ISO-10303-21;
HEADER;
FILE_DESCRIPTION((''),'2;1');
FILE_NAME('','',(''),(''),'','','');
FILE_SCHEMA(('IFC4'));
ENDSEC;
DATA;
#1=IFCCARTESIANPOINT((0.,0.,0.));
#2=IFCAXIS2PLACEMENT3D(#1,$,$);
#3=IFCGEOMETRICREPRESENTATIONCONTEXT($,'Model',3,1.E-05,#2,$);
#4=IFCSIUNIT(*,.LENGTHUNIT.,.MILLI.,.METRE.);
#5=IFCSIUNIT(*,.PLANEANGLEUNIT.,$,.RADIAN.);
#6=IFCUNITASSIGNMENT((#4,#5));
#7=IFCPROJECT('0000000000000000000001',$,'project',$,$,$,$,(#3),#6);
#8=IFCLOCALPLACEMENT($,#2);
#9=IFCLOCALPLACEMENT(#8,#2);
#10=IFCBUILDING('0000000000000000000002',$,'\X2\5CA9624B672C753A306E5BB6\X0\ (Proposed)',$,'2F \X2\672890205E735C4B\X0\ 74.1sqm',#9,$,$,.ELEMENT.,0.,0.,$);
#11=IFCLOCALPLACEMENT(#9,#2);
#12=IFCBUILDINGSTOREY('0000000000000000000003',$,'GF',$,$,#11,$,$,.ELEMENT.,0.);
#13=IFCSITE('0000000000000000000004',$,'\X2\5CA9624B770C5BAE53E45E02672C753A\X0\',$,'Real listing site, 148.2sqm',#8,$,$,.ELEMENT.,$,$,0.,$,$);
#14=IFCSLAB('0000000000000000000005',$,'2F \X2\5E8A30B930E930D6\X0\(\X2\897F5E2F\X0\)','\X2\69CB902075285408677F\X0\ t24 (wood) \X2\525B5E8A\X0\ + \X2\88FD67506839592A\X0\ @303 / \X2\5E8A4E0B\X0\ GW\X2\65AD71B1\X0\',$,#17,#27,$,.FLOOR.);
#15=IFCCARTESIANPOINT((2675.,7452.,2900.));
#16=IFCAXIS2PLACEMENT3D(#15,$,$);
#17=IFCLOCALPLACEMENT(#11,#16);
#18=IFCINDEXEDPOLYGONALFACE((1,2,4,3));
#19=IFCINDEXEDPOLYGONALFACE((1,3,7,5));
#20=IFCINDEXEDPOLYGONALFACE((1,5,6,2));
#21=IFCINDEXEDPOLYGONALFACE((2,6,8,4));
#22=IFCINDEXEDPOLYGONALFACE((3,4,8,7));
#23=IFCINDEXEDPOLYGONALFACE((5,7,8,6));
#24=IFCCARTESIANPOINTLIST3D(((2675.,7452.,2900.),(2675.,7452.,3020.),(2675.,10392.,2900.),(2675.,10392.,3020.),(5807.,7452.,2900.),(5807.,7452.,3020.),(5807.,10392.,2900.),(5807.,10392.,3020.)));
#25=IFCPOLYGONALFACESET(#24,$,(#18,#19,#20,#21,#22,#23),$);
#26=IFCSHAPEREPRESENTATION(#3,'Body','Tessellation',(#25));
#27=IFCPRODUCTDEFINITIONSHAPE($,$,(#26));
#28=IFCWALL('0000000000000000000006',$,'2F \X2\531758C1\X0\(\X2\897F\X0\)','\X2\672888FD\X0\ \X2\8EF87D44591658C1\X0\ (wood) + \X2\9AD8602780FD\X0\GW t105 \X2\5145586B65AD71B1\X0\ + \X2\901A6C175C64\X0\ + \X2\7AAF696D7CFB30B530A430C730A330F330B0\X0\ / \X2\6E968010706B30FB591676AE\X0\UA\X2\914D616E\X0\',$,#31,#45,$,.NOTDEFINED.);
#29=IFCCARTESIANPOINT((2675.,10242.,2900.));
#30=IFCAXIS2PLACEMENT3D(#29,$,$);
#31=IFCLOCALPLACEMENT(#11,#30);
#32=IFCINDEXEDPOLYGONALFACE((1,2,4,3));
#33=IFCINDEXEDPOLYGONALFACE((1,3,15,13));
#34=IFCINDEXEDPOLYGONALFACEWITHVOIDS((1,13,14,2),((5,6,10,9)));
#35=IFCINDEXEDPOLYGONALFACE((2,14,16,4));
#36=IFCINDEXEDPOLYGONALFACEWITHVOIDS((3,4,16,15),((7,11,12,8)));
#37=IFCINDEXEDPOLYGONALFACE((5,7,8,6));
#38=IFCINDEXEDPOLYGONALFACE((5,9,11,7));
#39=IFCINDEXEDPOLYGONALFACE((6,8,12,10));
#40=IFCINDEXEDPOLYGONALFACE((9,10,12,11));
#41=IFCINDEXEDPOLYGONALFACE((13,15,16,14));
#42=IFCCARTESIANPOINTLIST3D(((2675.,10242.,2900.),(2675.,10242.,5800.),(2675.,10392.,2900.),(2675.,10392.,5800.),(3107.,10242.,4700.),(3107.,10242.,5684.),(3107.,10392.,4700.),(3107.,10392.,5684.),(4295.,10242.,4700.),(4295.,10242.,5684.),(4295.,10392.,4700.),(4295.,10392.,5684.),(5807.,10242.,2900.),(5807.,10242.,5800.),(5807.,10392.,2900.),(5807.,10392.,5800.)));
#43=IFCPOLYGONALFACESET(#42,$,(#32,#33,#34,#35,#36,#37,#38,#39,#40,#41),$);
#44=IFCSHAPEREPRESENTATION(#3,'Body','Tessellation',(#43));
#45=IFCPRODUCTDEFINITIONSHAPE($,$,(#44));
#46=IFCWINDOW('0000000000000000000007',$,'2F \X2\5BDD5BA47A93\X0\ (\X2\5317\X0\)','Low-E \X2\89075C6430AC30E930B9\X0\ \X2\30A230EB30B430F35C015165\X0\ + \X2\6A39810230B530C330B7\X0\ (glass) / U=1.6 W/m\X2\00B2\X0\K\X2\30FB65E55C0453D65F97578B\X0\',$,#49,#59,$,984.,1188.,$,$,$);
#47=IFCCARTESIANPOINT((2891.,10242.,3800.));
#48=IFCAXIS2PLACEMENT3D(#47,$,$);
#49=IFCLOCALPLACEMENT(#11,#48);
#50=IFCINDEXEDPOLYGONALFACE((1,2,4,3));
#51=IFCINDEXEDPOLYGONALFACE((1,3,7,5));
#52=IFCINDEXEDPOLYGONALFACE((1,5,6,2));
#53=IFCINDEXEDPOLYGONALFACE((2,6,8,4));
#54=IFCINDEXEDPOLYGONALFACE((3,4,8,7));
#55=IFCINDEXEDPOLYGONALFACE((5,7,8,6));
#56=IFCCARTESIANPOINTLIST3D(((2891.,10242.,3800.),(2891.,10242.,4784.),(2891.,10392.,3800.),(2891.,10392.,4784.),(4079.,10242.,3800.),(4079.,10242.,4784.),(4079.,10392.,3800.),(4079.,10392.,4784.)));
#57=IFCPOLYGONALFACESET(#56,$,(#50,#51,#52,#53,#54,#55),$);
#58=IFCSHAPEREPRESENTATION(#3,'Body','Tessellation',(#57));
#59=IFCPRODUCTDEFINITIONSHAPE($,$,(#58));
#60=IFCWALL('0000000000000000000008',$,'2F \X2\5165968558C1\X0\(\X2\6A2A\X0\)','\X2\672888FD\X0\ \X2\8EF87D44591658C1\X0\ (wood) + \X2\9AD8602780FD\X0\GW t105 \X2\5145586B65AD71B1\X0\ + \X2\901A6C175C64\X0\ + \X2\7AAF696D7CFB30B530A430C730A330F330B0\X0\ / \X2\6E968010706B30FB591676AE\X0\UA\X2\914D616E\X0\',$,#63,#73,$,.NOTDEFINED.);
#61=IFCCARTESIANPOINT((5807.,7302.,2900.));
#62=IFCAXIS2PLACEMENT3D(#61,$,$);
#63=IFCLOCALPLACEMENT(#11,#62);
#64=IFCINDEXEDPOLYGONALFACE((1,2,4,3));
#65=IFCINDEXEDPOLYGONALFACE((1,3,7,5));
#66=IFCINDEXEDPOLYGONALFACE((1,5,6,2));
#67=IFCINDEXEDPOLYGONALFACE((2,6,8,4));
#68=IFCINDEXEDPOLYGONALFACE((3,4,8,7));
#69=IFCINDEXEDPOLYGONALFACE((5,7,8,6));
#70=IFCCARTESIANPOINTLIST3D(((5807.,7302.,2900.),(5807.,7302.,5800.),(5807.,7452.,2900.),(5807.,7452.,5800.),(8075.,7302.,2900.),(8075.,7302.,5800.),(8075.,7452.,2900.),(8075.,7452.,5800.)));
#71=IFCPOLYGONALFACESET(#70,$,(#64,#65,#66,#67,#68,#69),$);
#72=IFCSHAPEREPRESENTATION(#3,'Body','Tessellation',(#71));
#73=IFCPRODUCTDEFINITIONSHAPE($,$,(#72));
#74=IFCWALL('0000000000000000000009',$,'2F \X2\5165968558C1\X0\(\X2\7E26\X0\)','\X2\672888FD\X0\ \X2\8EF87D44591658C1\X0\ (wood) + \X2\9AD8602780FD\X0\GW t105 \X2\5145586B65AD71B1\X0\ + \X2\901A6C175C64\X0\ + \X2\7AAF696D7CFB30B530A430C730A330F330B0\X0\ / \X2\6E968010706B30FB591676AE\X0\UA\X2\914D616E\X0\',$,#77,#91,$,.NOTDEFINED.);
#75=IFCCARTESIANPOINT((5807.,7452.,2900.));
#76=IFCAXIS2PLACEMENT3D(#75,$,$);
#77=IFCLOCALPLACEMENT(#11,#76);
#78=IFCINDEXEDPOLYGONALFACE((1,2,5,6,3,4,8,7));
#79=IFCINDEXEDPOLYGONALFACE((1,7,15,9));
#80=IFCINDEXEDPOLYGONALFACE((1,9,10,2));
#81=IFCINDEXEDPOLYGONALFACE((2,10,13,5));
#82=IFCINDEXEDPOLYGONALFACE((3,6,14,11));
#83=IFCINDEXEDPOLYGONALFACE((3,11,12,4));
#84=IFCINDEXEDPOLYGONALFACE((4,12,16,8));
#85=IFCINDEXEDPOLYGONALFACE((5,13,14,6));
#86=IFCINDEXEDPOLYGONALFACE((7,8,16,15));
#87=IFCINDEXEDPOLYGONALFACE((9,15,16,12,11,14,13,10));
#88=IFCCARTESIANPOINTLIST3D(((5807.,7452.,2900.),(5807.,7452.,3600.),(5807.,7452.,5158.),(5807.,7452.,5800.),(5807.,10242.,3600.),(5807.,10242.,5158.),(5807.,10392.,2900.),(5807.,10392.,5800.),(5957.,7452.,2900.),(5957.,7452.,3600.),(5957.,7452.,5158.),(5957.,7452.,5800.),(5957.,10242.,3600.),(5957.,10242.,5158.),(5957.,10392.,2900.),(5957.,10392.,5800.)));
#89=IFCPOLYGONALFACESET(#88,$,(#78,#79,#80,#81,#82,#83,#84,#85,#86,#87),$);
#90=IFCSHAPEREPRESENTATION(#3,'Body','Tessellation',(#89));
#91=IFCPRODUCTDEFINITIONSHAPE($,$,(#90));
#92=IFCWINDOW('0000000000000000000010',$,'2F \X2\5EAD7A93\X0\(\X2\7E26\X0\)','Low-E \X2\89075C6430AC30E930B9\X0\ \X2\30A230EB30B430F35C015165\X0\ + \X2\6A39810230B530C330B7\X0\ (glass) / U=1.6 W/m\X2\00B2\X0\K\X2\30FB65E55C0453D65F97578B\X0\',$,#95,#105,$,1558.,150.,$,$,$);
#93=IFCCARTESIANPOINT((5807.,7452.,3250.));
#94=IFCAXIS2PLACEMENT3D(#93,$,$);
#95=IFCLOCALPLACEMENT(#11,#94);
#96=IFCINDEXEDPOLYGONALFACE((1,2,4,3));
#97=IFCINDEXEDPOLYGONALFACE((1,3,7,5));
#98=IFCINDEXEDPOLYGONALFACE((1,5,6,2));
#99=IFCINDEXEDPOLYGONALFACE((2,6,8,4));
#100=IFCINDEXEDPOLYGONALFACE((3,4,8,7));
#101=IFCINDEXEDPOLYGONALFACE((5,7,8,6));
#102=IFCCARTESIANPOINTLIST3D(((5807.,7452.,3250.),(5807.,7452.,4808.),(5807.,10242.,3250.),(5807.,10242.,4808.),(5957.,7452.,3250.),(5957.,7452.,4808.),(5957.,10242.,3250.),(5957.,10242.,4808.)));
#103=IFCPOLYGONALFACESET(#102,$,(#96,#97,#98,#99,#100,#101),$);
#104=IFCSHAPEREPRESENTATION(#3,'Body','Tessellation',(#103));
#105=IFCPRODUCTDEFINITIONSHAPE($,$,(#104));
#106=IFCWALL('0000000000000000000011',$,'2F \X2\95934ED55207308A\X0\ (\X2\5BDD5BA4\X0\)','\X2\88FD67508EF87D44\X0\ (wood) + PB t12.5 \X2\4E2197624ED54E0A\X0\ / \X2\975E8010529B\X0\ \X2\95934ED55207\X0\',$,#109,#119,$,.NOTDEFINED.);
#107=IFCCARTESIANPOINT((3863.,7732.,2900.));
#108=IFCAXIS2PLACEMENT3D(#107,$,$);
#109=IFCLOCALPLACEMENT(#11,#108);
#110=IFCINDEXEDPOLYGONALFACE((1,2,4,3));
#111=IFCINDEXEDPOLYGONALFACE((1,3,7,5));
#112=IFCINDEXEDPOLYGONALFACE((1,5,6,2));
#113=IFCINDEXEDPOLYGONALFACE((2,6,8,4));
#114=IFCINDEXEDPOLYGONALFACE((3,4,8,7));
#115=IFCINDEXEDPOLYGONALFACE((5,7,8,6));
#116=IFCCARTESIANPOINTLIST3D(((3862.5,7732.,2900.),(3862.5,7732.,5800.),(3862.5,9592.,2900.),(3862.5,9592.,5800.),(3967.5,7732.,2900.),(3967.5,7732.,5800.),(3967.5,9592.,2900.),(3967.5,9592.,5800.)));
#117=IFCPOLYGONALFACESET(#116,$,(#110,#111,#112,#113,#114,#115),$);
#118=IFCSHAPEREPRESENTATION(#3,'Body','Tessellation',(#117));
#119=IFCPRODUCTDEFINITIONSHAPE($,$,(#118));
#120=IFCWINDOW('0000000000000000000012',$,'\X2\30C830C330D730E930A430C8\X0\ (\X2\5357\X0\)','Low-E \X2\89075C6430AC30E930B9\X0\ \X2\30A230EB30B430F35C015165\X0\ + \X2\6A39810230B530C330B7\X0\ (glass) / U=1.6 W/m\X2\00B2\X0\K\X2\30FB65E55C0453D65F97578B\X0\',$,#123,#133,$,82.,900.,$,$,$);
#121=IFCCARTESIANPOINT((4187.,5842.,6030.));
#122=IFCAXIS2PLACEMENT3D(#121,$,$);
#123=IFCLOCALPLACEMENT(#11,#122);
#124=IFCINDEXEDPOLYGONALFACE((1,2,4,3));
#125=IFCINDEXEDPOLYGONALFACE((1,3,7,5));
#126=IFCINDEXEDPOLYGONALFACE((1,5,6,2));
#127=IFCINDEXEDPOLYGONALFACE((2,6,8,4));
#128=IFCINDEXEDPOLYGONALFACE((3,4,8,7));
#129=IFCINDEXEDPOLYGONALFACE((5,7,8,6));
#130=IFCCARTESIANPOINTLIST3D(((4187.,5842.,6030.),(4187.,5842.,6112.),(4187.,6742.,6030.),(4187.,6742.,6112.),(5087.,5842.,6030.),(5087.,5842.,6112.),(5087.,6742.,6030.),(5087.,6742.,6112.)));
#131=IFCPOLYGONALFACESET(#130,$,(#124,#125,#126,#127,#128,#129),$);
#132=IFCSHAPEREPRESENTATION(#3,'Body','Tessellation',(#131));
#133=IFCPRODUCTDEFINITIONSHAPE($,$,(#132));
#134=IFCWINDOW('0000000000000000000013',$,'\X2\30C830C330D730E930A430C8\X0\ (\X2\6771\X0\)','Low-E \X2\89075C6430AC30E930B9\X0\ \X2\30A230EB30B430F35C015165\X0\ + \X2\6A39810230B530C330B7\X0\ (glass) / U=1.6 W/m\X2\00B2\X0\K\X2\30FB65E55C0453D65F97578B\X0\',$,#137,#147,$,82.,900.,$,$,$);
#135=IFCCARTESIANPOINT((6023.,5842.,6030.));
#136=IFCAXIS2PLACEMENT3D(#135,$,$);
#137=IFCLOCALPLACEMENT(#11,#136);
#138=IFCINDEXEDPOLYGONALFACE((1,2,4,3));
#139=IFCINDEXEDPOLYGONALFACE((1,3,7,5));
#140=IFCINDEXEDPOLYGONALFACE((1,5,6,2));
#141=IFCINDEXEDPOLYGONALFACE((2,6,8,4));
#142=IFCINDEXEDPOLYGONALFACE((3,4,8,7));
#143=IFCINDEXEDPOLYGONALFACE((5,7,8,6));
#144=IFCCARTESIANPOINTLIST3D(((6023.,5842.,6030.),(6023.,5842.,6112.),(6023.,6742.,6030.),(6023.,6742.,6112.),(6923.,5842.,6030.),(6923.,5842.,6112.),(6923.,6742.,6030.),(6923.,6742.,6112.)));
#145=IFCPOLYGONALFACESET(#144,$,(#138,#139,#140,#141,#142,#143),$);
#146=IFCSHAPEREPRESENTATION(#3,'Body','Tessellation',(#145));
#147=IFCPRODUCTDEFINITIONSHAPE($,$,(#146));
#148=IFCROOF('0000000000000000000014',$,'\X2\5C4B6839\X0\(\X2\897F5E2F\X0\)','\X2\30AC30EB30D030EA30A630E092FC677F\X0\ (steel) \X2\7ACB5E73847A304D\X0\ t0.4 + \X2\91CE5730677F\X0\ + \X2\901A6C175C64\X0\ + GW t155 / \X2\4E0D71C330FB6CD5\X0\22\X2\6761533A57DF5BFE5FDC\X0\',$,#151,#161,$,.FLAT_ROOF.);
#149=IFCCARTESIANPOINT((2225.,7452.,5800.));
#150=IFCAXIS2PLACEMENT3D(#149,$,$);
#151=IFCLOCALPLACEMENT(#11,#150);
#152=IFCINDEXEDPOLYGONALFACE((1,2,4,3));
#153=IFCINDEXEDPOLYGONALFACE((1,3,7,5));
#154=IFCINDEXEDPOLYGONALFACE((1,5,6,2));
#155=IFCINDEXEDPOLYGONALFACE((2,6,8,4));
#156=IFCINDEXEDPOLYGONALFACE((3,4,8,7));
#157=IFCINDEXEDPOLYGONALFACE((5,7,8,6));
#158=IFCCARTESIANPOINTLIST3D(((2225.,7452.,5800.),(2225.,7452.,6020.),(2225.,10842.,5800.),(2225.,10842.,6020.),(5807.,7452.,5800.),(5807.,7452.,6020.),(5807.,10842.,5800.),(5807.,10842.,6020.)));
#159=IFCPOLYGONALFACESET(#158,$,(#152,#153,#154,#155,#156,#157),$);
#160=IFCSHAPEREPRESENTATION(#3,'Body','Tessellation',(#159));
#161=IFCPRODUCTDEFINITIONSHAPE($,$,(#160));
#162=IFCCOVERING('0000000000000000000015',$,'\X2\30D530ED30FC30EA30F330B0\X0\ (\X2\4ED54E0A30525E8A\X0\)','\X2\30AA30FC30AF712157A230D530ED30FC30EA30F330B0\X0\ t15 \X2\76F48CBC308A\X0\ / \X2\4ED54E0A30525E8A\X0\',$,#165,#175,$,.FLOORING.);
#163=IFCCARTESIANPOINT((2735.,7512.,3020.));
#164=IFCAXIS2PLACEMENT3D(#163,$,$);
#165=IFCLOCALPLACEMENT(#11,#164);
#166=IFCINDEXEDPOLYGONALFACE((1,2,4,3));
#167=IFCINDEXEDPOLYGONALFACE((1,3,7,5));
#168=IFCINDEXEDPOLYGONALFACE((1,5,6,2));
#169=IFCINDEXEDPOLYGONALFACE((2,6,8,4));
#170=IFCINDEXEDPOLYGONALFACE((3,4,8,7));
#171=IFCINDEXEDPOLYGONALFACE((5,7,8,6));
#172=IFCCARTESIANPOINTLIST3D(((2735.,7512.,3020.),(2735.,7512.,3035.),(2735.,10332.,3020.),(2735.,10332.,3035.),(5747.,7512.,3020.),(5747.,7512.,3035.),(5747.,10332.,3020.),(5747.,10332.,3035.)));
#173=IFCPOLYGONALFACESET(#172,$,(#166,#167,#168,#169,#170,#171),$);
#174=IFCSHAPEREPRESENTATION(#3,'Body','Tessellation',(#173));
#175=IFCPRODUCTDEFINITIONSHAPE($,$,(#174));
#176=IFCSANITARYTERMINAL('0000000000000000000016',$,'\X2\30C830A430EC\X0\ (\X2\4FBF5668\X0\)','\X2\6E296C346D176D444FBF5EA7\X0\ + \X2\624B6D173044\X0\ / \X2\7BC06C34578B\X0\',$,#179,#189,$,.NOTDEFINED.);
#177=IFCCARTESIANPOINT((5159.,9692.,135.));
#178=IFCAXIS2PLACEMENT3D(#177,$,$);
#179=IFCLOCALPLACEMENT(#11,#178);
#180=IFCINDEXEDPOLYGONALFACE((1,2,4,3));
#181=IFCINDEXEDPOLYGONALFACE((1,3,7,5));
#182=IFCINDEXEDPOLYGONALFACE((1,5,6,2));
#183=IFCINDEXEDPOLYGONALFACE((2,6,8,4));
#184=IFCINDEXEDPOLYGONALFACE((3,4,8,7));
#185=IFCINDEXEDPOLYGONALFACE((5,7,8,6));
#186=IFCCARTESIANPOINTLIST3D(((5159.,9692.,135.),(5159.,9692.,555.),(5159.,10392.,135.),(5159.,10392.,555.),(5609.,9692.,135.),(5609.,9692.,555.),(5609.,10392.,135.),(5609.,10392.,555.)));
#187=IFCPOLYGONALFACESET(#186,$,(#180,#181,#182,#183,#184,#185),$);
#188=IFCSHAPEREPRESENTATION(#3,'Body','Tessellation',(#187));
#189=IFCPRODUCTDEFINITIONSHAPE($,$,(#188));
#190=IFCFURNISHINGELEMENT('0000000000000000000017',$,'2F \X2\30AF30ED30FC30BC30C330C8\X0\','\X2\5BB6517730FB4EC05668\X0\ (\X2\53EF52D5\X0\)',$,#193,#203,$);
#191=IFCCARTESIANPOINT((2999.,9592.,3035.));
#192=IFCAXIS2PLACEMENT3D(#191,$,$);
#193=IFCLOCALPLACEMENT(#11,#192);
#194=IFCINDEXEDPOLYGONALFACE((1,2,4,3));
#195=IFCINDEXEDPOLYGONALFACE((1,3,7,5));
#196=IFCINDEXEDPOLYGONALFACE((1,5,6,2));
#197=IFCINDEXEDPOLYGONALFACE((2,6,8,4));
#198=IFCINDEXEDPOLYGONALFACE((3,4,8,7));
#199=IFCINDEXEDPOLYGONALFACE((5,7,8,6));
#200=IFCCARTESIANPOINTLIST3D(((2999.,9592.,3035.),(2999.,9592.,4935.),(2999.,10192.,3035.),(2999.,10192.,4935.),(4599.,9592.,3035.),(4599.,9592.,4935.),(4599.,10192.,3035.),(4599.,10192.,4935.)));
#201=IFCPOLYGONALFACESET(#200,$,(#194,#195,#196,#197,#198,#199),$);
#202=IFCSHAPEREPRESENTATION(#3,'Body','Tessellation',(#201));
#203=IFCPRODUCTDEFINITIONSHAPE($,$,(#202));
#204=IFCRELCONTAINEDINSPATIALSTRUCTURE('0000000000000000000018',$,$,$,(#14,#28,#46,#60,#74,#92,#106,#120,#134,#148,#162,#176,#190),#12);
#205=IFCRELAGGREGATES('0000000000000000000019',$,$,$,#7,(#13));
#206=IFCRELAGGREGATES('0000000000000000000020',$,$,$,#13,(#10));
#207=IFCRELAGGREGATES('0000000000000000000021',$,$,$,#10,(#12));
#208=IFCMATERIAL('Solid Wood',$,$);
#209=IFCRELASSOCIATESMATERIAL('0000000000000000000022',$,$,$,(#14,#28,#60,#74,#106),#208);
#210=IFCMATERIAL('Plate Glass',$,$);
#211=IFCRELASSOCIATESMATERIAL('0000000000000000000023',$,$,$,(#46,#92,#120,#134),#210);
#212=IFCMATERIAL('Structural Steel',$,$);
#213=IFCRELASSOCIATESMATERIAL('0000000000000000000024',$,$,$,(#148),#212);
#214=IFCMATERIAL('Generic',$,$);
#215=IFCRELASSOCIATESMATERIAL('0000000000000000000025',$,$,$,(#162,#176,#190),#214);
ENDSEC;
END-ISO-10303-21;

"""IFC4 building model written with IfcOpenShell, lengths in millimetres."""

from ifc_helpers import new_model, si_unit, frame, frame_2d, origin, place, context, project, spatial, rectangle, extrude, material, element, fill, save


model = new_model("IFC4")

# Units and contexts
model_context = context("Model", 3, precision=1e-05, world=origin())
ifc_project = project(units=[si_unit("LENGTHUNIT", "METRE", prefix="MILLI"), si_unit("PLANEANGLEUNIT", "RADIAN")], contexts=[model_context])

# Site, building, storey
site_placement = place(None, origin())
site = spatial("IfcSite", under=ifc_project, at=site_placement, Name="岩手県宮古市本町", ObjectType="Real listing site, 148.2sqm", CompositionType="ELEMENT", RefElevation=0.0)
building_placement = place(site_placement, origin())
building = spatial("IfcBuilding", under=site, at=building_placement, Name="岩手本町の家 (Proposed)", ObjectType="2F 木造平屋 74.1sqm", CompositionType="ELEMENT", ElevationOfRefHeight=0.0, ElevationOfTerrain=0.0)
storey_placement = place(building_placement, origin())
storey = spatial("IfcBuildingStorey", under=building, at=storey_placement, Name="GF", CompositionType="ELEMENT", Elevation=0.0)

# Slab
ifc_material_1 = material(Name="Solid Wood")
slab_placement = place(storey_placement, frame((2675.0, 7452.0, 2900.0)))
element("IfcSlab", 1, at=slab_placement, inside=storey, material=ifc_material_1, Name="2F 床スラブ(西帯)", Description="構造用合板 t24 (wood) 剛床 + 製材根太 @303 / 床下 GW断熱", PredefinedType="FLOOR", context=model_context, shape_type="SweptSolid", body=[
    extrude(rectangle(XDim=3132.0, YDim=2940.0, at=frame_2d((1566.0, 1470.0))), frame((2675.0, 7452.0, 2900.0)), (0.0, 0.0, 1.0), 120.0),
])

# Wall, opening, window
wall_1_placement = place(storey_placement, frame((2675.0, 10242.0, 2900.0)))
wall_1 = element("IfcWall", 2, at=wall_1_placement, inside=storey, material=ifc_material_1, Name="2F 北壁(西)", Description="木製 軸組外壁 (wood) + 高性能GW t105 充填断熱 + 通気層 + 窯業系サイディング / 準耐火・外皮UA配慮", PredefinedType="NOTDEFINED", context=model_context, shape_type="SweptSolid", body=[
    extrude(rectangle(XDim=3132.0, YDim=150.0, at=frame_2d((1566.0, 75.0))), frame((2675.0, 10242.0, 2900.0)), (0.0, 0.0, 1.0), 2900.0),
])
opening_1_placement = place(storey_placement, frame((2891.0, 10242.0, 3800.0)))
opening_1 = element("IfcOpeningElement", 3, at=opening_1_placement, cuts=wall_1, PredefinedType="NOTDEFINED", context=model_context, shape_type="SweptSolid", body=[
    extrude(rectangle(XDim=1188.0, YDim=150.0, at=frame_2d((594.0, 75.0))), frame((2891.0, 10242.0, 3800.0)), (0.0, 0.0, 1.0), 984.0),
])
ifc_material_2 = material(Name="Plate Glass")
window_1_placement = place(storey_placement, frame((2891.0, 10242.0, 3800.0)))
window_1 = element("IfcWindow", 4, at=window_1_placement, inside=storey, material=ifc_material_2, Name="2F 寝室窓 (北)", Description="Low-E 複層ガラス アルゴン封入 + 樹脂サッシ (glass) / U=1.6 W/m²K・日射取得型", OverallHeight=984.0, OverallWidth=1188.0, context=model_context, shape_type="SweptSolid", body=[
    extrude(rectangle(XDim=1188.0, YDim=150.0, at=frame_2d((594.0, 75.0))), frame((2891.0, 10242.0, 3800.0)), (0.0, 0.0, 1.0), 984.0),
])
fill(opening_1, window_1)

# Wall
wall_2_placement = place(storey_placement, frame((5807.0, 7302.0, 2900.0)))
element("IfcWall", 5, at=wall_2_placement, inside=storey, material=ifc_material_1, Name="2F 入隅壁(横)", Description="木製 軸組外壁 (wood) + 高性能GW t105 充填断熱 + 通気層 + 窯業系サイディング / 準耐火・外皮UA配慮", PredefinedType="NOTDEFINED", context=model_context, shape_type="SweptSolid", body=[
    extrude(rectangle(XDim=2268.0, YDim=150.0, at=frame_2d((1134.0, 75.0))), frame((5807.0, 7302.0, 2900.0)), (0.0, 0.0, 1.0), 2900.0),
])

# Wall, opening, window
wall_3_placement = place(storey_placement, frame((5807.0, 7452.0, 2900.0)))
wall_3 = element("IfcWall", 6, at=wall_3_placement, inside=storey, material=ifc_material_1, Name="2F 入隅壁(縦)", Description="木製 軸組外壁 (wood) + 高性能GW t105 充填断熱 + 通気層 + 窯業系サイディング / 準耐火・外皮UA配慮", PredefinedType="NOTDEFINED", context=model_context, shape_type="SweptSolid", body=[
    extrude(rectangle(XDim=150.0, YDim=2940.0, at=frame_2d((75.0, 1470.0))), frame((5807.0, 7452.0, 2900.0)), (0.0, 0.0, 1.0), 2900.0),
])
opening_2_placement = place(storey_placement, frame((5807.0, 7452.0, 3250.0)))
opening_2 = element("IfcOpeningElement", 7, at=opening_2_placement, cuts=wall_3, PredefinedType="NOTDEFINED", context=model_context, shape_type="SweptSolid", body=[
    extrude(rectangle(XDim=150.0, YDim=2790.0, at=frame_2d((75.0, 1395.0))), frame((5807.0, 7452.0, 3250.0)), (0.0, 0.0, 1.0), 1558.0),
])
window_2_placement = place(storey_placement, frame((5807.0, 7452.0, 3250.0)))
window_2 = element("IfcWindow", 8, at=window_2_placement, inside=storey, material=ifc_material_2, Name="2F 庭窓(縦)", Description="Low-E 複層ガラス アルゴン封入 + 樹脂サッシ (glass) / U=1.6 W/m²K・日射取得型", OverallHeight=1558.0, OverallWidth=150.0, context=model_context, shape_type="SweptSolid", body=[
    extrude(rectangle(XDim=150.0, YDim=2790.0, at=frame_2d((75.0, 1395.0))), frame((5807.0, 7452.0, 3250.0)), (0.0, 0.0, 1.0), 1558.0),
])
fill(opening_2, window_2)

# Wall
wall_4_placement = place(storey_placement, frame((3863.0, 7732.0, 2900.0)))
element("IfcWall", 9, at=wall_4_placement, inside=storey, material=ifc_material_1, Name="2F 間仕切り (寝室)", Description="製材軸組 (wood) + PB t12.5 両面仕上 / 非耐力 間仕切", PredefinedType="NOTDEFINED", context=model_context, shape_type="SweptSolid", body=[
    extrude(rectangle(XDim=105.0, YDim=1860.0, at=frame_2d((52.0, 930.0))), frame((3863.0, 7732.0, 2900.0)), (0.0, 0.0, 1.0), 2900.0),
])

# Windows
window_3_placement = place(storey_placement, frame((4187.0, 5842.0, 6030.0)))
element("IfcWindow", 10, at=window_3_placement, inside=storey, material=ifc_material_2, Name="トップライト (南)", Description="Low-E 複層ガラス アルゴン封入 + 樹脂サッシ (glass) / U=1.6 W/m²K・日射取得型", OverallHeight=82.0, OverallWidth=900.0, context=model_context, shape_type="SweptSolid", body=[
    extrude(rectangle(XDim=900.0, YDim=900.0, at=frame_2d((450.0, 450.0))), frame((4187.0, 5842.0, 6030.0)), (0.0, 0.0, 1.0), 82.0),
])
window_4_placement = place(storey_placement, frame((6023.0, 5842.0, 6030.0)))
element("IfcWindow", 11, at=window_4_placement, inside=storey, material=ifc_material_2, Name="トップライト (東)", Description="Low-E 複層ガラス アルゴン封入 + 樹脂サッシ (glass) / U=1.6 W/m²K・日射取得型", OverallHeight=82.0, OverallWidth=900.0, context=model_context, shape_type="SweptSolid", body=[
    extrude(rectangle(XDim=900.0, YDim=900.0, at=frame_2d((450.0, 450.0))), frame((6023.0, 5842.0, 6030.0)), (0.0, 0.0, 1.0), 82.0),
])

# Roof
ifc_material_3 = material(Name="Structural Steel")
for number, where, name in (
    (12, (2225.0, 7452.0, 5800.0), "屋根(西帯)"),
):
    element("IfcRoof", number, at=place(storey_placement, frame(where)), inside=storey, material=ifc_material_3, Name=name, Description="ガルバリウム鋼板 (steel) 立平葺き t0.4 + 野地板 + 通気層 + GW t155 / 不燃・法22条区域対応", PredefinedType="FLAT_ROOF", context=model_context, shape_type="SweptSolid", body=[
        extrude(rectangle(XDim=3582.0, YDim=3390.0, at=frame_2d((1791.0, 1695.0))), frame((2225.0, 7452.0, 5800.0)), (0.0, 0.0, 1.0), 220.0),
    ])

# Covering
ifc_material_4 = material(Name="Generic")
covering_placement = place(storey_placement, frame((2735.0, 7512.0, 3020.0)))
element("IfcCovering", 13, at=covering_placement, inside=storey, material=ifc_material_4, Name="フローリング (仕上げ床)", Description="オーク無垢フローリング t15 直貼り / 仕上げ床", PredefinedType="FLOORING", context=model_context, shape_type="SweptSolid", body=[
    extrude(rectangle(XDim=3012.0, YDim=2820.0, at=frame_2d((1506.0, 1410.0))), frame((2735.0, 7512.0, 3020.0)), (0.0, 0.0, 1.0), 15.0),
])

# Sanitary terminal
sanitary_terminal_placement = place(storey_placement, frame((5159.0, 9692.0, 135.0)))
element("IfcSanitaryTerminal", 14, at=sanitary_terminal_placement, inside=storey, material=ifc_material_4, Name="トイレ (便器)", Description="温水洗浄便座 + 手洗い / 節水型", PredefinedType="NOTDEFINED", context=model_context, shape_type="SweptSolid", body=[
    extrude(rectangle(XDim=450.0, YDim=700.0, at=frame_2d((225.0, 350.0))), frame((5159.0, 9692.0, 135.0)), (0.0, 0.0, 1.0), 420.0),
])

# Furnishing element
furnishing_1_placement = place(storey_placement, frame((2999.0, 9592.0, 3035.0)))
element("IfcFurnishingElement", 15, at=furnishing_1_placement, inside=storey, material=ifc_material_4, Name="2F クローゼット", Description="家具・什器 (可動)", context=model_context, shape_type="SweptSolid", body=[
    extrude(rectangle(XDim=1600.0, YDim=600.0, at=frame_2d((800.0, 300.0))), frame((2999.0, 9592.0, 3035.0)), (0.0, 0.0, 1.0), 1900.0),
])

save(model, "model.ifc")
